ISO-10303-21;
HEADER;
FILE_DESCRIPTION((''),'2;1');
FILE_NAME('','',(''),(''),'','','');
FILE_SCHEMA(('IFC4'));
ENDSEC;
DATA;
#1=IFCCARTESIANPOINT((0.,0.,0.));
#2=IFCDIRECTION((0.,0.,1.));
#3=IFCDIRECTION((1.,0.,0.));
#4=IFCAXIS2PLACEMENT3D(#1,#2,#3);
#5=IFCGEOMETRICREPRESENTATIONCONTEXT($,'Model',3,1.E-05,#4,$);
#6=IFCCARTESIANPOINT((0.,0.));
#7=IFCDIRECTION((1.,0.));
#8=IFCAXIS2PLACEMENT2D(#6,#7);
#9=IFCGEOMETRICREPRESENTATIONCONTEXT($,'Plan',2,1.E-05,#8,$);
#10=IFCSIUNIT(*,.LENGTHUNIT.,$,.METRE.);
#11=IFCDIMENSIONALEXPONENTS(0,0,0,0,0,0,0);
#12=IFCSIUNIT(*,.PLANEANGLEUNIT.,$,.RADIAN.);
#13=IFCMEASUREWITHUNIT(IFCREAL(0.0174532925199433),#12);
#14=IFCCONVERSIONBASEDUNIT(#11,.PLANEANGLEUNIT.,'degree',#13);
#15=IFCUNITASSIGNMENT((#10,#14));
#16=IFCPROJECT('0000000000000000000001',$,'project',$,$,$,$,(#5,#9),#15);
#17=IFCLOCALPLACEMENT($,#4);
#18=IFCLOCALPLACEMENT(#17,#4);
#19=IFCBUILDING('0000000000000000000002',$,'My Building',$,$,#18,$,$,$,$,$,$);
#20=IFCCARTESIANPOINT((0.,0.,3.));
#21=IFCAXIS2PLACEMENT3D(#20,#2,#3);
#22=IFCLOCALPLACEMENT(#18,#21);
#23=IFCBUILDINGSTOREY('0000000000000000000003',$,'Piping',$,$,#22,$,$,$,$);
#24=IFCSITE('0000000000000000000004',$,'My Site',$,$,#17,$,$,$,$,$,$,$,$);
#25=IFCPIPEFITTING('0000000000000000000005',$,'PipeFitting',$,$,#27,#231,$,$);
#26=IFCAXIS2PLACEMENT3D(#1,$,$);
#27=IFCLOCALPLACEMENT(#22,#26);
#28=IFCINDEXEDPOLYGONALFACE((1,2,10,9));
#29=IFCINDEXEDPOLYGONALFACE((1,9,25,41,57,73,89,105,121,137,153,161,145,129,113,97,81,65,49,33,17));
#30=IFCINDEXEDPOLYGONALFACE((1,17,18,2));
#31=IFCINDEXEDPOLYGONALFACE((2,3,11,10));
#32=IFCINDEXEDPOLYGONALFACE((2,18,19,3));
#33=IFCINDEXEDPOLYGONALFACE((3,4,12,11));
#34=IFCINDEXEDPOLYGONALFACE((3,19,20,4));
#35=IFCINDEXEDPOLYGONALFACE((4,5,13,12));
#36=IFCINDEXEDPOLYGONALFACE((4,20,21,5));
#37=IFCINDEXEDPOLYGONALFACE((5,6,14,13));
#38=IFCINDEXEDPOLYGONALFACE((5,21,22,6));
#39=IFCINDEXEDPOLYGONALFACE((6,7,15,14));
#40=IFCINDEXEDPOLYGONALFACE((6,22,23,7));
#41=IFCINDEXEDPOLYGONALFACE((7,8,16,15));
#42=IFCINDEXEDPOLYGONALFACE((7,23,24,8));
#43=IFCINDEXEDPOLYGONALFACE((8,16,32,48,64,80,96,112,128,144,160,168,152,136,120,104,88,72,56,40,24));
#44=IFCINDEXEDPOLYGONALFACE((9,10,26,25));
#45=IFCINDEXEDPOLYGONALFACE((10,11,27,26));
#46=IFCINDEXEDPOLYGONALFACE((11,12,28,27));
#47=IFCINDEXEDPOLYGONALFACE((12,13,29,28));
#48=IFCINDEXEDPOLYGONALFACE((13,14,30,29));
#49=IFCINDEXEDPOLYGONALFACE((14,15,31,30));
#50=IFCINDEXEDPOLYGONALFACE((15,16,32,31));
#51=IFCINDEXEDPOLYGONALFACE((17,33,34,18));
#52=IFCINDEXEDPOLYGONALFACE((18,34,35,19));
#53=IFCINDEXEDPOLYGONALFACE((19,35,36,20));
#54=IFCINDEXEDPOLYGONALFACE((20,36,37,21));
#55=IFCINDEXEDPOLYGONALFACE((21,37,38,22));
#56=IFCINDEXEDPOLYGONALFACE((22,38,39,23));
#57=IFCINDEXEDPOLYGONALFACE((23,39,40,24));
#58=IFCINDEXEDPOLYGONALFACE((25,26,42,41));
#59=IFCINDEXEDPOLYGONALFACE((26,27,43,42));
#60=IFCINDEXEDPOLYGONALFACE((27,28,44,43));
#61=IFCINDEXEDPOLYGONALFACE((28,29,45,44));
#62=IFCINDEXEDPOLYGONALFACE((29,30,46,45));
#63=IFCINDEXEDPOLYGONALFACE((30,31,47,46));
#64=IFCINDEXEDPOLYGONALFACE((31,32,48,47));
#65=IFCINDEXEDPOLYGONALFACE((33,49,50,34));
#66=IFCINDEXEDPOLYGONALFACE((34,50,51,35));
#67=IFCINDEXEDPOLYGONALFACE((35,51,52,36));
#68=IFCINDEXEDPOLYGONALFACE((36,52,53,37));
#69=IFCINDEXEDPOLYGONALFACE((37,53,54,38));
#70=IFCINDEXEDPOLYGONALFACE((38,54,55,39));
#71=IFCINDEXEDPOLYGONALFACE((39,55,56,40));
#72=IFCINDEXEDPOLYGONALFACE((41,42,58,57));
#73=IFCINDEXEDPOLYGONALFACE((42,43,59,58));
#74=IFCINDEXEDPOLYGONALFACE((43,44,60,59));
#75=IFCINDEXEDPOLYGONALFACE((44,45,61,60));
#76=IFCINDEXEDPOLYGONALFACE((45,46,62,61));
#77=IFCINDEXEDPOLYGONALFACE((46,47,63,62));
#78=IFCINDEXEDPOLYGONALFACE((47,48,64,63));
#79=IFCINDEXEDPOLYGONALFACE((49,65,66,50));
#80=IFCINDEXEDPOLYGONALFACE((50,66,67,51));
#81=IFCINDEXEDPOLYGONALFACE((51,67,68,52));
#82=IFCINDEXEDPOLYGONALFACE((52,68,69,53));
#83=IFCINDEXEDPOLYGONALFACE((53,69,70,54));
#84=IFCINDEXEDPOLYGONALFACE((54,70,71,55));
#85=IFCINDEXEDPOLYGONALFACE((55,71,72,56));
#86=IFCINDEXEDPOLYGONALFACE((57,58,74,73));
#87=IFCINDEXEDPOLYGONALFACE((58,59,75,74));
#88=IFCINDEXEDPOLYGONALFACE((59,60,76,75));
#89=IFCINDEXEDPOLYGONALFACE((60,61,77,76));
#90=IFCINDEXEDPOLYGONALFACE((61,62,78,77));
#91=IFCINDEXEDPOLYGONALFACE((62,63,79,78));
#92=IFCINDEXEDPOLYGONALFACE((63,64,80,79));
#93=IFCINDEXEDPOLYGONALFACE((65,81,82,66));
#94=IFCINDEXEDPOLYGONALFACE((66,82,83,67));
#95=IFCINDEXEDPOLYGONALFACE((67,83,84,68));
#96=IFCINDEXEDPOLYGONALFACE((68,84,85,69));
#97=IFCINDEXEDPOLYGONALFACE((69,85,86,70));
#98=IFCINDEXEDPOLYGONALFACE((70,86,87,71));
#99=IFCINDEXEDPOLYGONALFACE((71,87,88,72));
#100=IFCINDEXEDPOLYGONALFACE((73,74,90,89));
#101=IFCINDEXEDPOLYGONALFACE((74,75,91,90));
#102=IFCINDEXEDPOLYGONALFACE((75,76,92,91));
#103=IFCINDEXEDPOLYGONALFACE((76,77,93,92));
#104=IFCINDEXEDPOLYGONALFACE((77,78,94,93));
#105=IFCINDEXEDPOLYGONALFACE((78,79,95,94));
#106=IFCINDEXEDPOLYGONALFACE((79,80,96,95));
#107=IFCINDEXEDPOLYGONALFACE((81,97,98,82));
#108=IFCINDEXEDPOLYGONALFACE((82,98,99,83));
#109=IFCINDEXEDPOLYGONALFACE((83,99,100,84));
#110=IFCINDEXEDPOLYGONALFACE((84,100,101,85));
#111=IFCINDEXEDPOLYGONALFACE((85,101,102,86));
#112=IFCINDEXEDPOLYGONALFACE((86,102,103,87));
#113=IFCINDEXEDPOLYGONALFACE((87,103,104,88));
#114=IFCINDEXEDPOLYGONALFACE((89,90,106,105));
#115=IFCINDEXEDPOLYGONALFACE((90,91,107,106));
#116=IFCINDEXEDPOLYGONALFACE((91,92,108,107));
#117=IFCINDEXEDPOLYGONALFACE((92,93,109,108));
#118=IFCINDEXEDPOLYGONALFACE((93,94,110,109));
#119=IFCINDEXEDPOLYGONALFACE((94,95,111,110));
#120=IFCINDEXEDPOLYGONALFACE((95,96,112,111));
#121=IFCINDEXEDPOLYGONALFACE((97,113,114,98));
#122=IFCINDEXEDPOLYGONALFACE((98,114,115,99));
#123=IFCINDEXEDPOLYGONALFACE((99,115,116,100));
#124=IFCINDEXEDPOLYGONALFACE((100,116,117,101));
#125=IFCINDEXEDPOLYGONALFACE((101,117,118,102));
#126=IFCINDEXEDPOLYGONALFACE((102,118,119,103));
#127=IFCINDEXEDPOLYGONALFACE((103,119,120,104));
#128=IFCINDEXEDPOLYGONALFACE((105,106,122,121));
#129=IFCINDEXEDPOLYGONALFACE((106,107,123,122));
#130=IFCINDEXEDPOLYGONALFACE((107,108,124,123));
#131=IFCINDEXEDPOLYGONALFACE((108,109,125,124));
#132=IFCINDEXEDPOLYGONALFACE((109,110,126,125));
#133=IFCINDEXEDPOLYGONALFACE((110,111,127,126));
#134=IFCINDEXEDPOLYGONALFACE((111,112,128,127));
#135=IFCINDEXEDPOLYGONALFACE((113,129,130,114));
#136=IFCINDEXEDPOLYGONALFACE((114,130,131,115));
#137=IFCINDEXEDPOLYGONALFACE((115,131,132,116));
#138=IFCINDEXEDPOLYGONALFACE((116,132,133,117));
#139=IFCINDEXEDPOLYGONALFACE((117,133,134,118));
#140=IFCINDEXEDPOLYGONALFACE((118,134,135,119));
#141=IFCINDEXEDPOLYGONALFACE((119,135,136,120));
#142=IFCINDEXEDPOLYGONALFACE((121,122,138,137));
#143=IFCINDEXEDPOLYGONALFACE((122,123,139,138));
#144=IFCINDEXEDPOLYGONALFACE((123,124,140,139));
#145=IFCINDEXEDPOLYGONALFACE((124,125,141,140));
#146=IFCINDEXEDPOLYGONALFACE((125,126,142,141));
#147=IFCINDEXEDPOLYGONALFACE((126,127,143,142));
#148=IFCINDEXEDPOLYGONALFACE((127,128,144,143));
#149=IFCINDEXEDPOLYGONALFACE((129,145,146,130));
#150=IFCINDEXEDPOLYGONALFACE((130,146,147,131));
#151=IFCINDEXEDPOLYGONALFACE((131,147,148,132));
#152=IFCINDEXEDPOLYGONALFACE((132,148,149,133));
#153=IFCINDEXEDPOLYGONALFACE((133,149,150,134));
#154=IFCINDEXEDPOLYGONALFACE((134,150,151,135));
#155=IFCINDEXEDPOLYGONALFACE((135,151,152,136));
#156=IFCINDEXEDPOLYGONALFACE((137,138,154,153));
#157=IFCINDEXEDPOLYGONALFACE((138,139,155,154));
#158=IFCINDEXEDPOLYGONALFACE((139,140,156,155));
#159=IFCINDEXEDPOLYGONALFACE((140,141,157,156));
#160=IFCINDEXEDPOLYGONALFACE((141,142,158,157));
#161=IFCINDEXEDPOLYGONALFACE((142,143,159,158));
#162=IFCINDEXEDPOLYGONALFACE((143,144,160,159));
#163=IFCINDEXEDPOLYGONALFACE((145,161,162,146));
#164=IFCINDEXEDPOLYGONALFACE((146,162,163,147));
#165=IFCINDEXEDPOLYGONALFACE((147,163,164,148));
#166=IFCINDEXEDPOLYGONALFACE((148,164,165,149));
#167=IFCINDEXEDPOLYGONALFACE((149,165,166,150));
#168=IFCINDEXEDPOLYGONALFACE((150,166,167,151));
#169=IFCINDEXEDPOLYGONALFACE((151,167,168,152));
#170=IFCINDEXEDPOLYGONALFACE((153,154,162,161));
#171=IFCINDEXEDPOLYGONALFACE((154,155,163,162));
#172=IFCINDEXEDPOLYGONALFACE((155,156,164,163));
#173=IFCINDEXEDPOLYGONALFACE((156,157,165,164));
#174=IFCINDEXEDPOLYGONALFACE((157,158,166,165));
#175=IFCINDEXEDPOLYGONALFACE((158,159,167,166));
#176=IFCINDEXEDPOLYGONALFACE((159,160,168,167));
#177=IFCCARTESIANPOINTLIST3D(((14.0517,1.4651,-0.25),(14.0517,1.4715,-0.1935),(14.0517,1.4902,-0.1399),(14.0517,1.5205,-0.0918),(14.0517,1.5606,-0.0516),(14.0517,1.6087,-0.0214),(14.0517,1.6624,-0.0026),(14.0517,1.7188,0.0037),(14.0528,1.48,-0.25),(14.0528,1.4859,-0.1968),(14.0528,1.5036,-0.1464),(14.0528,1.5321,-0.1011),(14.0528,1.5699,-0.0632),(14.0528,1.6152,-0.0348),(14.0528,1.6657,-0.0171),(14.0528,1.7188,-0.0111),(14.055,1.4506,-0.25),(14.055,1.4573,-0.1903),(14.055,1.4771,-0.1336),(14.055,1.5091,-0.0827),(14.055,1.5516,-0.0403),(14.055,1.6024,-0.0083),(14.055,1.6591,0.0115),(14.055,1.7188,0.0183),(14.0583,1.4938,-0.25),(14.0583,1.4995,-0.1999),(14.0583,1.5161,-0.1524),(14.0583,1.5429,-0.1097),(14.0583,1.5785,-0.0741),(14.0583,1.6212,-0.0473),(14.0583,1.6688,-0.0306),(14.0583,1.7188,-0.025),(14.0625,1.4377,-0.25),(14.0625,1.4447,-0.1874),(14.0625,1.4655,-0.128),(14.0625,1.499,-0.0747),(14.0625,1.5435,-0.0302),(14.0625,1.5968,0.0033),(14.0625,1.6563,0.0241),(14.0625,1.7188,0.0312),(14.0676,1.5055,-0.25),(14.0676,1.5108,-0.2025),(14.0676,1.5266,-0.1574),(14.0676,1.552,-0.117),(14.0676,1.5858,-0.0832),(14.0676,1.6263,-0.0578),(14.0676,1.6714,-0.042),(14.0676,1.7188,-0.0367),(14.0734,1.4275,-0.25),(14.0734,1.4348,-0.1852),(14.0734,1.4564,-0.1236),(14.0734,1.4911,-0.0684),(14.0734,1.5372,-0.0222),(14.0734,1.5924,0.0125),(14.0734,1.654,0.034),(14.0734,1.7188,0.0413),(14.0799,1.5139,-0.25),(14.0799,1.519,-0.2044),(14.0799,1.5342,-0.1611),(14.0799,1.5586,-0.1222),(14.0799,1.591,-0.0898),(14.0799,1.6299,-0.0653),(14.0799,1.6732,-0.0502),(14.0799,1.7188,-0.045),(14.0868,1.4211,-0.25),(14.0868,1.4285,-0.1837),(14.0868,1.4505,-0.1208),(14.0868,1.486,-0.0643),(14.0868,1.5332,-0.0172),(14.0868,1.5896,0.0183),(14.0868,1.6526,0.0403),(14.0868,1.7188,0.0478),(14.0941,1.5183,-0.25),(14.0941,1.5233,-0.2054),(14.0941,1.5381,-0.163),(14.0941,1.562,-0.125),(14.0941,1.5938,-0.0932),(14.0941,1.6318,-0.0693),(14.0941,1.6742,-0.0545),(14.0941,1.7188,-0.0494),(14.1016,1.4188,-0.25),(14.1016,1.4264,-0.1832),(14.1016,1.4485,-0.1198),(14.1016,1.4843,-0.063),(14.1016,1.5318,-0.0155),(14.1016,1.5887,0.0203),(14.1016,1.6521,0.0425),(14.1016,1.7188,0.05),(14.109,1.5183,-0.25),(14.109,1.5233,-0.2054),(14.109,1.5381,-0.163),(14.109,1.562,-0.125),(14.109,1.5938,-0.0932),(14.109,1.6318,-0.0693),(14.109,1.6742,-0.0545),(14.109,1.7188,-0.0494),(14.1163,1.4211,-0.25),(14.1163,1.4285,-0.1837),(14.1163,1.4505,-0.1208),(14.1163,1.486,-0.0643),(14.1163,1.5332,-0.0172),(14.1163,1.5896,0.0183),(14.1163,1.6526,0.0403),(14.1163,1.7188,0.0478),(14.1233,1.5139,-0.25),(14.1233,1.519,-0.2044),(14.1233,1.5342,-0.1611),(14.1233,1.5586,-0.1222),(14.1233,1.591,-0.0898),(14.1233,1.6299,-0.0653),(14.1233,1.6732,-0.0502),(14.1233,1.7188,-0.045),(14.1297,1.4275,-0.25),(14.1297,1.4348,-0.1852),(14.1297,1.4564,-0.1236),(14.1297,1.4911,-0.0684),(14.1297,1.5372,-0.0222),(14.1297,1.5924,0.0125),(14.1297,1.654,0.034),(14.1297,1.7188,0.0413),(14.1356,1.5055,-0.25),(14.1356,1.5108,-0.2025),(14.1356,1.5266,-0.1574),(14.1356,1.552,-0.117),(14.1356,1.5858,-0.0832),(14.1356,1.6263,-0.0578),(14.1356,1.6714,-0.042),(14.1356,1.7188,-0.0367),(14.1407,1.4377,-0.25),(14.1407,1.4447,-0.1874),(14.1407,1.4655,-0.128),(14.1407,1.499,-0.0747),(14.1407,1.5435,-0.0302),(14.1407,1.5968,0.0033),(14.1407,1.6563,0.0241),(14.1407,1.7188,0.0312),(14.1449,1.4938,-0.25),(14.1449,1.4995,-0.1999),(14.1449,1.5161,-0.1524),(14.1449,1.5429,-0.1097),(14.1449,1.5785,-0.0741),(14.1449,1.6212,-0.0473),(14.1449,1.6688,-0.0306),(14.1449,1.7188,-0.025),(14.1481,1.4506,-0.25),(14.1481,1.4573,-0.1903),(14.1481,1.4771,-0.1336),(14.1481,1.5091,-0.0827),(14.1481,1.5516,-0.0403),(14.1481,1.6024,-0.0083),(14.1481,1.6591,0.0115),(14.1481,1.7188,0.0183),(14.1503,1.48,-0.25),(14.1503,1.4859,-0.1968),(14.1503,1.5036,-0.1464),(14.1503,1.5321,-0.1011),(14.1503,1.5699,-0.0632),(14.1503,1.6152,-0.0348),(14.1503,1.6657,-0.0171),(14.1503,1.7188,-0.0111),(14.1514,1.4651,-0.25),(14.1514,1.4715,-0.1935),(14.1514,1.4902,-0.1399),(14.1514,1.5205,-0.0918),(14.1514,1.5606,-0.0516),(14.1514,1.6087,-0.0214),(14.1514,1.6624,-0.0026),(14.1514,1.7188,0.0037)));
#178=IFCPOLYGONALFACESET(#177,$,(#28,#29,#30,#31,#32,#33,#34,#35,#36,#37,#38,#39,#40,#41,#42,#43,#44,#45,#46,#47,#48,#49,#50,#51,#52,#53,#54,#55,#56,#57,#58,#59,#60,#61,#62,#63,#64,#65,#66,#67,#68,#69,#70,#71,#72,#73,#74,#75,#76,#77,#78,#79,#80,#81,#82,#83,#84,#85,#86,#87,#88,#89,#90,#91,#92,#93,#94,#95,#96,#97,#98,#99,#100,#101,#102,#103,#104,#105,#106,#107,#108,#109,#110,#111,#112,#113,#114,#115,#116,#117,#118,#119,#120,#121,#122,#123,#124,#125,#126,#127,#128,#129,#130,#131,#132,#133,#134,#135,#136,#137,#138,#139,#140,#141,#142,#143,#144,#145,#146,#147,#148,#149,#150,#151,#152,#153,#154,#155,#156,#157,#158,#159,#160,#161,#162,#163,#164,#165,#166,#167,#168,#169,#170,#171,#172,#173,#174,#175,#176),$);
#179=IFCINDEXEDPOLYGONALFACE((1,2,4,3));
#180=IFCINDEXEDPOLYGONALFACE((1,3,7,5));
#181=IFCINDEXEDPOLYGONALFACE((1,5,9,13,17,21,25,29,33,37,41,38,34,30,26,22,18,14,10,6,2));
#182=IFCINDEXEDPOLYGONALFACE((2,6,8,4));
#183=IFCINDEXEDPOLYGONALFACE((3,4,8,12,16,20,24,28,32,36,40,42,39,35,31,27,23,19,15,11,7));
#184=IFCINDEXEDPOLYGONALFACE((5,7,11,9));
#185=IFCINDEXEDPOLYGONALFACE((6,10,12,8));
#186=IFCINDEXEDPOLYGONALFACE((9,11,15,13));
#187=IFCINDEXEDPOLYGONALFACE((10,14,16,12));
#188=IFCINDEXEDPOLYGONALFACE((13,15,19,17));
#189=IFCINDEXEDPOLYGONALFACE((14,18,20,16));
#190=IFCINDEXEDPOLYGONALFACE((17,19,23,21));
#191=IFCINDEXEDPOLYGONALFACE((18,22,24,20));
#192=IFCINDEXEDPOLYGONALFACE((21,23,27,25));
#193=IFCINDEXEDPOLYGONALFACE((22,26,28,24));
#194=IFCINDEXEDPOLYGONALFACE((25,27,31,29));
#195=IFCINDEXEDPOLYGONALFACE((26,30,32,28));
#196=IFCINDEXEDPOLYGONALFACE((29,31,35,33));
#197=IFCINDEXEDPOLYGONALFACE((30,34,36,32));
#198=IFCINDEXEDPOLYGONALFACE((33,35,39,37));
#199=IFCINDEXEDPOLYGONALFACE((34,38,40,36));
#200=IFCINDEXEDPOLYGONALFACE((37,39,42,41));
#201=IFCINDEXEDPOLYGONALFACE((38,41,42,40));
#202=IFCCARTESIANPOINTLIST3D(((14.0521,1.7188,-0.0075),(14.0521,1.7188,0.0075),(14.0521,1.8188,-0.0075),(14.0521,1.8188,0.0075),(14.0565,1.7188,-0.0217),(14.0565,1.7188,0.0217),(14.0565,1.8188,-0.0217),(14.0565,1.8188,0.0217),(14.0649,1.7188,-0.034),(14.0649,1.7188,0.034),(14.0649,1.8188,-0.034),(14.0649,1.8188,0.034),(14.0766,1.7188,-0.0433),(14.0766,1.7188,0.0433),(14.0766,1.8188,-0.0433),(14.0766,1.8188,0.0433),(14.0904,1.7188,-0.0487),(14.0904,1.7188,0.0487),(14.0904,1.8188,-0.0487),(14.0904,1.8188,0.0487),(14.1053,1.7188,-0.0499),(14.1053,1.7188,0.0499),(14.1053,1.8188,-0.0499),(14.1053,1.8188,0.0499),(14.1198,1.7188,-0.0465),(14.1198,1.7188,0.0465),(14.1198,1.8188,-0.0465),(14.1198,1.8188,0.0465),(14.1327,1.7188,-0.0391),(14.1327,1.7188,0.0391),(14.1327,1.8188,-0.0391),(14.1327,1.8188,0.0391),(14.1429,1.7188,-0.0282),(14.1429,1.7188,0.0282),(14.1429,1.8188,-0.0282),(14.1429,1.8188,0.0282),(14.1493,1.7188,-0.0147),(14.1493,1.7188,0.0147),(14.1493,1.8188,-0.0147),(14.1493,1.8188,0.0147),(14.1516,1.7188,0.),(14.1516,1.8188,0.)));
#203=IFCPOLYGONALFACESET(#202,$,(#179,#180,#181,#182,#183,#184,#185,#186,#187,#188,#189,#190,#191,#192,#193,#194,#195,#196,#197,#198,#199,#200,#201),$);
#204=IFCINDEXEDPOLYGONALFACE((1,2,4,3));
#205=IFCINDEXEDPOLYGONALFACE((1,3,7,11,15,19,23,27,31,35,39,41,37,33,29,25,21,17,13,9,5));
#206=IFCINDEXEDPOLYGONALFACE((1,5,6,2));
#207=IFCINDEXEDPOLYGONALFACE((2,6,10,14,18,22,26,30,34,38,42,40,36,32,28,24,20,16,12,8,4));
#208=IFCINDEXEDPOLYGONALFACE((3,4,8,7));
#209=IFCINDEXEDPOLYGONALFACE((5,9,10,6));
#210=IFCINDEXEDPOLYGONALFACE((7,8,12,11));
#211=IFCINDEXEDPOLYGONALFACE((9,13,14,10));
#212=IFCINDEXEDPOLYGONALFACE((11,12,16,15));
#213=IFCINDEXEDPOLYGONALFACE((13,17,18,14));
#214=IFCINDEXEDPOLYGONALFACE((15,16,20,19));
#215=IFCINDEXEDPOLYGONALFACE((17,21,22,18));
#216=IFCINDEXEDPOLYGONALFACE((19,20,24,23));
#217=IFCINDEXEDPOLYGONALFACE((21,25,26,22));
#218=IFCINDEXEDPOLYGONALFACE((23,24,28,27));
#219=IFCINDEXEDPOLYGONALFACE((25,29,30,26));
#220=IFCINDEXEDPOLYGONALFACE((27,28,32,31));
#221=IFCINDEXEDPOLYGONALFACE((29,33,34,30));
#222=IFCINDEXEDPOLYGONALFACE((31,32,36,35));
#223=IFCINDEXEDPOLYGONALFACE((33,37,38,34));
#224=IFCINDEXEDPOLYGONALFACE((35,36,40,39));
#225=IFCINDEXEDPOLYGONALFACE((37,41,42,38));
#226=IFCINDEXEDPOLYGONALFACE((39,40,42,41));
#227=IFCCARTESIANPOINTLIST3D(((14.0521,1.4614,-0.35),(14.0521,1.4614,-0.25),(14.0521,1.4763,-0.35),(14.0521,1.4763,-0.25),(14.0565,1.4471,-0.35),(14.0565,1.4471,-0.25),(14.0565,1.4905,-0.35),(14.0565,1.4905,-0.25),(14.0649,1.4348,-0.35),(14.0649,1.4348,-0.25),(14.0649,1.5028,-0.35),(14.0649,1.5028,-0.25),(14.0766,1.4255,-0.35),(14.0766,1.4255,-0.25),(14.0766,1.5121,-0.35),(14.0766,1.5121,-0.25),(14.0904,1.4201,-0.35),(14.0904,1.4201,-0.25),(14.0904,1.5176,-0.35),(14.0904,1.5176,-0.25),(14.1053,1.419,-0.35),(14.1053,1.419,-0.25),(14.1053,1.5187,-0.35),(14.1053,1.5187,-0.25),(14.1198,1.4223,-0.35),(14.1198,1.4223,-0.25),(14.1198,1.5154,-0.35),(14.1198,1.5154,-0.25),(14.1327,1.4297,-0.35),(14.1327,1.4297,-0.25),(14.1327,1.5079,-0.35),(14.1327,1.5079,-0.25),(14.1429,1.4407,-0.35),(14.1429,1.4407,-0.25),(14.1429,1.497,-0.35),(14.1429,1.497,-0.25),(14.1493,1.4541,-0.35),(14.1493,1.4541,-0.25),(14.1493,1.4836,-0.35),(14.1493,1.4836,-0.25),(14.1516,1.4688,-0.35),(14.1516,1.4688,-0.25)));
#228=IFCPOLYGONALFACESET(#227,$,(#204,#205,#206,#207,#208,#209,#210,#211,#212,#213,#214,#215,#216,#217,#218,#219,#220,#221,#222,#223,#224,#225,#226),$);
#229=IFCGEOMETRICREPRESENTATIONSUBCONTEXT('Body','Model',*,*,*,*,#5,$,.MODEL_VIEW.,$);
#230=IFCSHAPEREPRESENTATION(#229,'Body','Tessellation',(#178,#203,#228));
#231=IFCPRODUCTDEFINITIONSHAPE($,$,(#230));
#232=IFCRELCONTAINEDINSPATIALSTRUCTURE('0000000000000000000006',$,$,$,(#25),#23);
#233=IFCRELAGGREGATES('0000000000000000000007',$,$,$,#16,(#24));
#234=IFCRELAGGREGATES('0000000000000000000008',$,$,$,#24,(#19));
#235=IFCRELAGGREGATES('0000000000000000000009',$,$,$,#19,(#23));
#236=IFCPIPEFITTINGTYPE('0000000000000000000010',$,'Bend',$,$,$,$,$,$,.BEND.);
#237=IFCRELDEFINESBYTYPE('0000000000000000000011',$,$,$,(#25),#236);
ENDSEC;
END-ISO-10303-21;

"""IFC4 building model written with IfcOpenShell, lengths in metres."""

from ifc_helpers import new_model, entity, si_unit, converted_unit, frame, origin_with_axes, origin_2d_with_axis, place, context, subcontext, project, spatial, circle, extrude, source, transform, mapped, type_object, type_shapes, element, save


model = new_model("IFC4")

# Units and contexts
model_context = context("Model", 3, precision=1e-05, world=origin_with_axes())
plan_context = context("Plan", 2, precision=1e-05, world=origin_2d_with_axis())
body_context = subcontext(model_context, "Body", "Model", "MODEL_VIEW")
ifc_project = project(units=[si_unit("LENGTHUNIT", "METRE"), converted_unit("PLANEANGLEUNIT", "degree", entity("IfcReal", 0.0174532925199433), si_unit("PLANEANGLEUNIT", "RADIAN"), dimensions=[0, 0, 0, 0, 0, 0, 0])], contexts=[model_context, plan_context])

# Site, building, storey
site_placement = place(None, origin_with_axes())
site = spatial("IfcSite", under=ifc_project, at=site_placement, Name="My Site")
building_placement = place(site_placement, origin_with_axes())
building = spatial("IfcBuilding", under=site, at=building_placement, Name="My Building")
storey_placement = place(building_placement, frame((0.0, 0.0, 3.0), z_axis=(0.0, 0.0, 1.0), x_axis=(1.0, 0.0, 0.0)))
storey = spatial("IfcBuildingStorey", under=building, at=storey_placement, Name="Piping")

# Shared definitions
pipe_fitting_type = type_object("IfcPipeFittingType", Name="Bend", PredefinedType="BEND")
shared_shape = source(origin_with_axes(), body_context, "Body", "SolidModel", [
    entity("IfcSweptDiskSolid", entity("IfcIndexedPolyCurve", entity("IfcCartesianPointList3D", [[0.0, 0.0, -0.1], [0.0, 0.0732, -0.2768], [0.0, 0.25, -0.35]]), [entity("IfcArcIndex", [1, 2, 3])]), 0.05),
    extrude(circle(Radius=0.05), origin_with_axes(), (0.0, 0.0, -1.0), 0.1),
    extrude(circle(Radius=0.05), frame((0.0, 0.25, -0.35), z_axis=(0.0, 1.0, 0.0), x_axis=(1.0, 0.0, 0.0)), (0.0, 0.0, 1.0), 0.1),
])
type_shapes(pipe_fitting_type, [shared_shape])

# Pipe fitting
for number, where, z_axis, x_axis, name in (
    (1, (14.1016, 1.8188, 0.0), (0.0, 1.0, 0.0), (1.0, 0.0, 0.0), "PipeFitting"),
):
    element("IfcPipeFitting", number, at=place(storey_placement, frame(where, z_axis=z_axis, x_axis=x_axis)), inside=storey, type_object=pipe_fitting_type, Name=name, context=body_context, shape_type="MappedRepresentation", body=[
        mapped(shared_shape, transform((0.0, 0.0, 0.0), x_axis=(1.0, 0.0, 0.0), y_axis=(0.0, 1.0, 0.0), z_axis=(0.0, 0.0, 1.0), scale=1.0)),
    ])

save(model, "model.ifc")
